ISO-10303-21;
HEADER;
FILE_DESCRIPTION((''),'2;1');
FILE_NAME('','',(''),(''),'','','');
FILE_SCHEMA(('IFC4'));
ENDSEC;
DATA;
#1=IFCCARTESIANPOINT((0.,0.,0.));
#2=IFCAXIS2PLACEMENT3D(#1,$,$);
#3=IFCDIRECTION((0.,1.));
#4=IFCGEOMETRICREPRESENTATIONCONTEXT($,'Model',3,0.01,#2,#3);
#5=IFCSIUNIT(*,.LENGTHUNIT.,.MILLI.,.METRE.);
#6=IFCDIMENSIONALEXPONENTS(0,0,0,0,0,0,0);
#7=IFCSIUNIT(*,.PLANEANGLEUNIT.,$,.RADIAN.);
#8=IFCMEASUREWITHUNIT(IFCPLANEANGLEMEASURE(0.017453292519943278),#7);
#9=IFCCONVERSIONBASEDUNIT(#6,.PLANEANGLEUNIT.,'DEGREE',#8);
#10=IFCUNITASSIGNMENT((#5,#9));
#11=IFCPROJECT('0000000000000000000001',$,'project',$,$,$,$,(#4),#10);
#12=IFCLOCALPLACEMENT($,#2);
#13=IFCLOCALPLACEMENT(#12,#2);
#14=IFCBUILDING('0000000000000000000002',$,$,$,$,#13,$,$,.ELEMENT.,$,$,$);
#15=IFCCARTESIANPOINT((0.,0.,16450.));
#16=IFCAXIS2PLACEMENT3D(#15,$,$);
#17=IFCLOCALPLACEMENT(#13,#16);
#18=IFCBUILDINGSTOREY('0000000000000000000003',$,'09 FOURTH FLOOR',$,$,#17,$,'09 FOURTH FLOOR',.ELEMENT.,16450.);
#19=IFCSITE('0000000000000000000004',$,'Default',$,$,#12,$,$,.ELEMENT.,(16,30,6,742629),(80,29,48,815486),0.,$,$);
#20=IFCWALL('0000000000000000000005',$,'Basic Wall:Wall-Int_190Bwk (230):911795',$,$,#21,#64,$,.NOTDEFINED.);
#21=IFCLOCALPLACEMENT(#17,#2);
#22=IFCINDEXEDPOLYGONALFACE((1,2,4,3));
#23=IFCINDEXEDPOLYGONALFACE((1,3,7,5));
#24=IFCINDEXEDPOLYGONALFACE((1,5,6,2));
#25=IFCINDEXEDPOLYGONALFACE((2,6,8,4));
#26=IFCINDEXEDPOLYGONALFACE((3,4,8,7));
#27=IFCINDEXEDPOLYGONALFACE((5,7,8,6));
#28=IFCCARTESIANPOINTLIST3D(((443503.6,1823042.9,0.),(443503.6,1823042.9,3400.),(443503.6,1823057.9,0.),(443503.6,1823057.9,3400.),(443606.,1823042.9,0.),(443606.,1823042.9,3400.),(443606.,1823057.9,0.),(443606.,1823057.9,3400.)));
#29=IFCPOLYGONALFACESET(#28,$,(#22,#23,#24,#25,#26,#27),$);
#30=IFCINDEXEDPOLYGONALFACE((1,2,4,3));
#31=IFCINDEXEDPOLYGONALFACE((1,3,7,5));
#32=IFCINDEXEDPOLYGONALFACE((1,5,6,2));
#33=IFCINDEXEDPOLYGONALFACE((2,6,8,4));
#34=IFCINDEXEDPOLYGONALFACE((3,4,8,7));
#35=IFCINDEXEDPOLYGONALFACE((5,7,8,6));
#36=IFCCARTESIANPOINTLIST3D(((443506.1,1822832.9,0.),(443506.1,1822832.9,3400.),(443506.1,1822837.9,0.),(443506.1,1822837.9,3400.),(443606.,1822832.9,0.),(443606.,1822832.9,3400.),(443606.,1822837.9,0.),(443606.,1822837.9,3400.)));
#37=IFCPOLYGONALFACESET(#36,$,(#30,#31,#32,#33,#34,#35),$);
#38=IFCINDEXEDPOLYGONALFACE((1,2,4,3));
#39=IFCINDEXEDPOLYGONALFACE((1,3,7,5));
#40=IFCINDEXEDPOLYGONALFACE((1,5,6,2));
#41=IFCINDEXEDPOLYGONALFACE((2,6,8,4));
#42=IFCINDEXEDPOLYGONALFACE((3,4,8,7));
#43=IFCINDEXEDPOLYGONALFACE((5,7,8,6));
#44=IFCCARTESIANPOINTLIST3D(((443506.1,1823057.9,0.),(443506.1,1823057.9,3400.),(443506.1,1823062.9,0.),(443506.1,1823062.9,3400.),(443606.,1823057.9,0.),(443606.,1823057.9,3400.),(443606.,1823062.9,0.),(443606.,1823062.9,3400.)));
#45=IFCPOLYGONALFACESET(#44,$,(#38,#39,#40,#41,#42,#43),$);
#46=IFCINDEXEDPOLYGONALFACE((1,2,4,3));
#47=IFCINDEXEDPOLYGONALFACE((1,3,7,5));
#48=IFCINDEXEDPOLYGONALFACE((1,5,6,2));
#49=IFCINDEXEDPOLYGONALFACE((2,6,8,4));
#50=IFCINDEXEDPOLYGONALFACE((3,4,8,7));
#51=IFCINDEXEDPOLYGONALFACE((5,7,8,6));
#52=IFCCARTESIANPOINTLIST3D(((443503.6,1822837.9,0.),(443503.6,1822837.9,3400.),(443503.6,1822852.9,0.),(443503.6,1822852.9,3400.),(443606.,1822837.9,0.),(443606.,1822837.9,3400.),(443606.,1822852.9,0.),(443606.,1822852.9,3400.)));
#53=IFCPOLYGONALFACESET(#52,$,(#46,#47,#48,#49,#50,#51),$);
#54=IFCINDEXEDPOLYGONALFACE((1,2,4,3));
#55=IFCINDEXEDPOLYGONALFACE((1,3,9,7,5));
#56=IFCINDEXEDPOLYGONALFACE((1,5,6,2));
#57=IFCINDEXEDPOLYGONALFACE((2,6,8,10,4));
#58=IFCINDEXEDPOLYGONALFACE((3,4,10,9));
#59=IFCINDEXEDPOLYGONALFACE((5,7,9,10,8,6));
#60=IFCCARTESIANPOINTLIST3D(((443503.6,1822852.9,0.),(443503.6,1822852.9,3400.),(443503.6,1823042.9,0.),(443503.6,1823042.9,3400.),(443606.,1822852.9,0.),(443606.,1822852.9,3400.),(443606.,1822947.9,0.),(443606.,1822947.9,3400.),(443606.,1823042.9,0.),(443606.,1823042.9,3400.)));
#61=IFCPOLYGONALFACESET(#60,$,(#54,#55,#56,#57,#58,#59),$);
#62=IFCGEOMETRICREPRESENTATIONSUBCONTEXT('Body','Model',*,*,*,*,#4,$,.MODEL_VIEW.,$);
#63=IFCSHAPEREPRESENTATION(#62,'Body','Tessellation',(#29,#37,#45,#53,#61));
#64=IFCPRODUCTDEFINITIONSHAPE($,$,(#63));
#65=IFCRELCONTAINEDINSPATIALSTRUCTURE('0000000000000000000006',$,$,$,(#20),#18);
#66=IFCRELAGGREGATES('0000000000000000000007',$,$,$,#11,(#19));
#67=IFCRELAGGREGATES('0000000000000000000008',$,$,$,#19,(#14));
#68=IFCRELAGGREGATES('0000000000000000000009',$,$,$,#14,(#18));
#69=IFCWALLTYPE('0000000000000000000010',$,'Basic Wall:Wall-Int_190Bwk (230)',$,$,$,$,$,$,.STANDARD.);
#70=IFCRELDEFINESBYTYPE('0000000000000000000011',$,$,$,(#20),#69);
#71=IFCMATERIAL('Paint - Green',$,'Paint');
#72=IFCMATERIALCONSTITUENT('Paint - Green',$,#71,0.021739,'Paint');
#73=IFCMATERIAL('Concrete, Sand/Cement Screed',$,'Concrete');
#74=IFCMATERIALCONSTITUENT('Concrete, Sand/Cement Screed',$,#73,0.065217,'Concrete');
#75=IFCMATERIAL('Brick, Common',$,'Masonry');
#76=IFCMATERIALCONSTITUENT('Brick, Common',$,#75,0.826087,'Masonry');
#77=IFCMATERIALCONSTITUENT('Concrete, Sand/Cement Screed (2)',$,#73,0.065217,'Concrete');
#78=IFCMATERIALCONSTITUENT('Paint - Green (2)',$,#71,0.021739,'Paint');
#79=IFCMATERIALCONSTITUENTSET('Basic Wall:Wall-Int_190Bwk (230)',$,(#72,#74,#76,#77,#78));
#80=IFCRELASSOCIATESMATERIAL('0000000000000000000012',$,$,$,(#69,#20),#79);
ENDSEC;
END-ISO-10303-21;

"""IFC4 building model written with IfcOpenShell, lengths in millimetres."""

from ifc_helpers import new_model, entity, si_unit, converted_unit, direction, frame, origin, place, context, subcontext, project, spatial, indexed_curve, outline, extrude, material, constituent, constituent_set, type_object, element, save


model = new_model("IFC4")

# Units and contexts
model_context = context("Model", 3, precision=0.01, world=origin(), true_north=direction((0.0, 1.0)))
body_context = subcontext(model_context, "Body", "Model", "MODEL_VIEW")
ifc_project = project(units=[si_unit("LENGTHUNIT", "METRE", prefix="MILLI"), converted_unit("PLANEANGLEUNIT", "DEGREE", entity("IfcPlaneAngleMeasure", 0.017453292519943278), si_unit("PLANEANGLEUNIT", "RADIAN"), dimensions=[0, 0, 0, 0, 0, 0, 0])], contexts=[model_context])

# Site, building, storey
site_placement = place(None, origin())
site = spatial("IfcSite", under=ifc_project, at=site_placement, Name="Default", CompositionType="ELEMENT", RefLatitude=(16, 30, 6, 742629), RefLongitude=(80, 29, 48, 815486), RefElevation=0.0)
building_placement = place(site_placement, origin())
building = spatial("IfcBuilding", under=site, at=building_placement, CompositionType="ELEMENT")
storey_placement = place(building_placement, frame((0.0, 0.0, 16450.0)))
storey = spatial("IfcBuildingStorey", under=building, at=storey_placement, Name="09 FOURTH FLOOR", LongName="09 FOURTH FLOOR", CompositionType="ELEMENT", Elevation=16450.0)

# Shared definitions
ifc_material_1 = material(Name="Concrete, Sand/Cement Screed", Category="Concrete")
ifc_material_2 = material(Name="Brick, Common", Category="Masonry")

# Shared definitions
ifc_material_3 = material(Name="Paint - Green", Category="Paint")

# Shared definitions
ifc_constituent_1 = constituent(ifc_material_3, Name="Paint - Green", Category="Paint", fraction=0.021739)
ifc_constituent_2 = constituent(ifc_material_1, Name="Concrete, Sand/Cement Screed", Category="Concrete", fraction=0.065217)
ifc_constituent_3 = constituent(ifc_material_2, Name="Brick, Common", Category="Masonry", fraction=0.826087)
ifc_constituent_4 = constituent(ifc_material_1, Name="Concrete, Sand/Cement Screed (2)", Category="Concrete", fraction=0.065217)
ifc_constituent_5 = constituent(ifc_material_3, Name="Paint - Green (2)", Category="Paint", fraction=0.021739)
ifc_constituent_set_1 = constituent_set(constituents=[ifc_constituent_1, ifc_constituent_2, ifc_constituent_3, ifc_constituent_4, ifc_constituent_5], Name="Basic Wall:Wall-Int_190Bwk (230)")
wall_type_1 = type_object("IfcWallType", Name="Basic Wall:Wall-Int_190Bwk (230)", PredefinedType="STANDARD", material=ifc_constituent_set_1)

# Wall
wall_1_placement = place(storey_placement, frame((443606.0, 1822947.9, 0.0), z_axis=(0.0, 0.0, 1.0), x_axis=(-1.0, 0.0, 0.0)))
element("IfcWall", 1, at=wall_1_placement, inside=storey, type_object=wall_type_1, material=ifc_constituent_set_1, Name="Basic Wall:Wall-Int_190Bwk (230):911795", PredefinedType="NOTDEFINED", context=body_context, shape_type="SweptSolid", body=[
    extrude(outline(indexed_curve([(-51.2, -7.5), (51.2, -7.5), (51.2, 7.5), (-51.2, 7.5), (-51.2, -7.5)], self_intersect=False)), frame((51.2, -102.5, 0.0)), (0.0, 0.0, 1.0), 3400.0),
    extrude(outline(indexed_curve([(-2.5, -49.9), (2.5, -49.9), (2.5, 49.9), (-2.5, 49.9), (-2.5, -49.9)], self_intersect=False)), frame((49.9, 112.5, 0.0), z_axis=(0.0, 0.0, 1.0), x_axis=(0.0, -1.0, 0.0)), (0.0, 0.0, 1.0), 3400.0),
    extrude(outline(indexed_curve([(-2.5, -49.9), (2.5, -49.9), (2.5, 49.9), (-2.5, 49.9), (-2.5, -49.9)], self_intersect=False)), frame((49.9, -112.5, 0.0), z_axis=(0.0, 0.0, 1.0), x_axis=(0.0, 1.0, 0.0)), (0.0, 0.0, 1.0), 3400.0),
    extrude(outline(indexed_curve([(-51.2, -7.5), (51.2, -7.5), (51.2, 7.5), (-51.2, 7.5), (-51.2, -7.5)], self_intersect=False)), frame((51.2, 102.5, 0.0)), (0.0, 0.0, 1.0), 3400.0),
    extrude(outline(indexed_curve([(-40.9, -95.0), (61.4, -95.0), (61.4, 95.0), (-40.9, 95.0), (-40.9, 0.0), (-40.9, -95.0)], self_intersect=False)), frame((40.9, 0.0, 0.0)), (0.0, 0.0, 1.0), 3400.0),
])

save(model, "model.ifc")
